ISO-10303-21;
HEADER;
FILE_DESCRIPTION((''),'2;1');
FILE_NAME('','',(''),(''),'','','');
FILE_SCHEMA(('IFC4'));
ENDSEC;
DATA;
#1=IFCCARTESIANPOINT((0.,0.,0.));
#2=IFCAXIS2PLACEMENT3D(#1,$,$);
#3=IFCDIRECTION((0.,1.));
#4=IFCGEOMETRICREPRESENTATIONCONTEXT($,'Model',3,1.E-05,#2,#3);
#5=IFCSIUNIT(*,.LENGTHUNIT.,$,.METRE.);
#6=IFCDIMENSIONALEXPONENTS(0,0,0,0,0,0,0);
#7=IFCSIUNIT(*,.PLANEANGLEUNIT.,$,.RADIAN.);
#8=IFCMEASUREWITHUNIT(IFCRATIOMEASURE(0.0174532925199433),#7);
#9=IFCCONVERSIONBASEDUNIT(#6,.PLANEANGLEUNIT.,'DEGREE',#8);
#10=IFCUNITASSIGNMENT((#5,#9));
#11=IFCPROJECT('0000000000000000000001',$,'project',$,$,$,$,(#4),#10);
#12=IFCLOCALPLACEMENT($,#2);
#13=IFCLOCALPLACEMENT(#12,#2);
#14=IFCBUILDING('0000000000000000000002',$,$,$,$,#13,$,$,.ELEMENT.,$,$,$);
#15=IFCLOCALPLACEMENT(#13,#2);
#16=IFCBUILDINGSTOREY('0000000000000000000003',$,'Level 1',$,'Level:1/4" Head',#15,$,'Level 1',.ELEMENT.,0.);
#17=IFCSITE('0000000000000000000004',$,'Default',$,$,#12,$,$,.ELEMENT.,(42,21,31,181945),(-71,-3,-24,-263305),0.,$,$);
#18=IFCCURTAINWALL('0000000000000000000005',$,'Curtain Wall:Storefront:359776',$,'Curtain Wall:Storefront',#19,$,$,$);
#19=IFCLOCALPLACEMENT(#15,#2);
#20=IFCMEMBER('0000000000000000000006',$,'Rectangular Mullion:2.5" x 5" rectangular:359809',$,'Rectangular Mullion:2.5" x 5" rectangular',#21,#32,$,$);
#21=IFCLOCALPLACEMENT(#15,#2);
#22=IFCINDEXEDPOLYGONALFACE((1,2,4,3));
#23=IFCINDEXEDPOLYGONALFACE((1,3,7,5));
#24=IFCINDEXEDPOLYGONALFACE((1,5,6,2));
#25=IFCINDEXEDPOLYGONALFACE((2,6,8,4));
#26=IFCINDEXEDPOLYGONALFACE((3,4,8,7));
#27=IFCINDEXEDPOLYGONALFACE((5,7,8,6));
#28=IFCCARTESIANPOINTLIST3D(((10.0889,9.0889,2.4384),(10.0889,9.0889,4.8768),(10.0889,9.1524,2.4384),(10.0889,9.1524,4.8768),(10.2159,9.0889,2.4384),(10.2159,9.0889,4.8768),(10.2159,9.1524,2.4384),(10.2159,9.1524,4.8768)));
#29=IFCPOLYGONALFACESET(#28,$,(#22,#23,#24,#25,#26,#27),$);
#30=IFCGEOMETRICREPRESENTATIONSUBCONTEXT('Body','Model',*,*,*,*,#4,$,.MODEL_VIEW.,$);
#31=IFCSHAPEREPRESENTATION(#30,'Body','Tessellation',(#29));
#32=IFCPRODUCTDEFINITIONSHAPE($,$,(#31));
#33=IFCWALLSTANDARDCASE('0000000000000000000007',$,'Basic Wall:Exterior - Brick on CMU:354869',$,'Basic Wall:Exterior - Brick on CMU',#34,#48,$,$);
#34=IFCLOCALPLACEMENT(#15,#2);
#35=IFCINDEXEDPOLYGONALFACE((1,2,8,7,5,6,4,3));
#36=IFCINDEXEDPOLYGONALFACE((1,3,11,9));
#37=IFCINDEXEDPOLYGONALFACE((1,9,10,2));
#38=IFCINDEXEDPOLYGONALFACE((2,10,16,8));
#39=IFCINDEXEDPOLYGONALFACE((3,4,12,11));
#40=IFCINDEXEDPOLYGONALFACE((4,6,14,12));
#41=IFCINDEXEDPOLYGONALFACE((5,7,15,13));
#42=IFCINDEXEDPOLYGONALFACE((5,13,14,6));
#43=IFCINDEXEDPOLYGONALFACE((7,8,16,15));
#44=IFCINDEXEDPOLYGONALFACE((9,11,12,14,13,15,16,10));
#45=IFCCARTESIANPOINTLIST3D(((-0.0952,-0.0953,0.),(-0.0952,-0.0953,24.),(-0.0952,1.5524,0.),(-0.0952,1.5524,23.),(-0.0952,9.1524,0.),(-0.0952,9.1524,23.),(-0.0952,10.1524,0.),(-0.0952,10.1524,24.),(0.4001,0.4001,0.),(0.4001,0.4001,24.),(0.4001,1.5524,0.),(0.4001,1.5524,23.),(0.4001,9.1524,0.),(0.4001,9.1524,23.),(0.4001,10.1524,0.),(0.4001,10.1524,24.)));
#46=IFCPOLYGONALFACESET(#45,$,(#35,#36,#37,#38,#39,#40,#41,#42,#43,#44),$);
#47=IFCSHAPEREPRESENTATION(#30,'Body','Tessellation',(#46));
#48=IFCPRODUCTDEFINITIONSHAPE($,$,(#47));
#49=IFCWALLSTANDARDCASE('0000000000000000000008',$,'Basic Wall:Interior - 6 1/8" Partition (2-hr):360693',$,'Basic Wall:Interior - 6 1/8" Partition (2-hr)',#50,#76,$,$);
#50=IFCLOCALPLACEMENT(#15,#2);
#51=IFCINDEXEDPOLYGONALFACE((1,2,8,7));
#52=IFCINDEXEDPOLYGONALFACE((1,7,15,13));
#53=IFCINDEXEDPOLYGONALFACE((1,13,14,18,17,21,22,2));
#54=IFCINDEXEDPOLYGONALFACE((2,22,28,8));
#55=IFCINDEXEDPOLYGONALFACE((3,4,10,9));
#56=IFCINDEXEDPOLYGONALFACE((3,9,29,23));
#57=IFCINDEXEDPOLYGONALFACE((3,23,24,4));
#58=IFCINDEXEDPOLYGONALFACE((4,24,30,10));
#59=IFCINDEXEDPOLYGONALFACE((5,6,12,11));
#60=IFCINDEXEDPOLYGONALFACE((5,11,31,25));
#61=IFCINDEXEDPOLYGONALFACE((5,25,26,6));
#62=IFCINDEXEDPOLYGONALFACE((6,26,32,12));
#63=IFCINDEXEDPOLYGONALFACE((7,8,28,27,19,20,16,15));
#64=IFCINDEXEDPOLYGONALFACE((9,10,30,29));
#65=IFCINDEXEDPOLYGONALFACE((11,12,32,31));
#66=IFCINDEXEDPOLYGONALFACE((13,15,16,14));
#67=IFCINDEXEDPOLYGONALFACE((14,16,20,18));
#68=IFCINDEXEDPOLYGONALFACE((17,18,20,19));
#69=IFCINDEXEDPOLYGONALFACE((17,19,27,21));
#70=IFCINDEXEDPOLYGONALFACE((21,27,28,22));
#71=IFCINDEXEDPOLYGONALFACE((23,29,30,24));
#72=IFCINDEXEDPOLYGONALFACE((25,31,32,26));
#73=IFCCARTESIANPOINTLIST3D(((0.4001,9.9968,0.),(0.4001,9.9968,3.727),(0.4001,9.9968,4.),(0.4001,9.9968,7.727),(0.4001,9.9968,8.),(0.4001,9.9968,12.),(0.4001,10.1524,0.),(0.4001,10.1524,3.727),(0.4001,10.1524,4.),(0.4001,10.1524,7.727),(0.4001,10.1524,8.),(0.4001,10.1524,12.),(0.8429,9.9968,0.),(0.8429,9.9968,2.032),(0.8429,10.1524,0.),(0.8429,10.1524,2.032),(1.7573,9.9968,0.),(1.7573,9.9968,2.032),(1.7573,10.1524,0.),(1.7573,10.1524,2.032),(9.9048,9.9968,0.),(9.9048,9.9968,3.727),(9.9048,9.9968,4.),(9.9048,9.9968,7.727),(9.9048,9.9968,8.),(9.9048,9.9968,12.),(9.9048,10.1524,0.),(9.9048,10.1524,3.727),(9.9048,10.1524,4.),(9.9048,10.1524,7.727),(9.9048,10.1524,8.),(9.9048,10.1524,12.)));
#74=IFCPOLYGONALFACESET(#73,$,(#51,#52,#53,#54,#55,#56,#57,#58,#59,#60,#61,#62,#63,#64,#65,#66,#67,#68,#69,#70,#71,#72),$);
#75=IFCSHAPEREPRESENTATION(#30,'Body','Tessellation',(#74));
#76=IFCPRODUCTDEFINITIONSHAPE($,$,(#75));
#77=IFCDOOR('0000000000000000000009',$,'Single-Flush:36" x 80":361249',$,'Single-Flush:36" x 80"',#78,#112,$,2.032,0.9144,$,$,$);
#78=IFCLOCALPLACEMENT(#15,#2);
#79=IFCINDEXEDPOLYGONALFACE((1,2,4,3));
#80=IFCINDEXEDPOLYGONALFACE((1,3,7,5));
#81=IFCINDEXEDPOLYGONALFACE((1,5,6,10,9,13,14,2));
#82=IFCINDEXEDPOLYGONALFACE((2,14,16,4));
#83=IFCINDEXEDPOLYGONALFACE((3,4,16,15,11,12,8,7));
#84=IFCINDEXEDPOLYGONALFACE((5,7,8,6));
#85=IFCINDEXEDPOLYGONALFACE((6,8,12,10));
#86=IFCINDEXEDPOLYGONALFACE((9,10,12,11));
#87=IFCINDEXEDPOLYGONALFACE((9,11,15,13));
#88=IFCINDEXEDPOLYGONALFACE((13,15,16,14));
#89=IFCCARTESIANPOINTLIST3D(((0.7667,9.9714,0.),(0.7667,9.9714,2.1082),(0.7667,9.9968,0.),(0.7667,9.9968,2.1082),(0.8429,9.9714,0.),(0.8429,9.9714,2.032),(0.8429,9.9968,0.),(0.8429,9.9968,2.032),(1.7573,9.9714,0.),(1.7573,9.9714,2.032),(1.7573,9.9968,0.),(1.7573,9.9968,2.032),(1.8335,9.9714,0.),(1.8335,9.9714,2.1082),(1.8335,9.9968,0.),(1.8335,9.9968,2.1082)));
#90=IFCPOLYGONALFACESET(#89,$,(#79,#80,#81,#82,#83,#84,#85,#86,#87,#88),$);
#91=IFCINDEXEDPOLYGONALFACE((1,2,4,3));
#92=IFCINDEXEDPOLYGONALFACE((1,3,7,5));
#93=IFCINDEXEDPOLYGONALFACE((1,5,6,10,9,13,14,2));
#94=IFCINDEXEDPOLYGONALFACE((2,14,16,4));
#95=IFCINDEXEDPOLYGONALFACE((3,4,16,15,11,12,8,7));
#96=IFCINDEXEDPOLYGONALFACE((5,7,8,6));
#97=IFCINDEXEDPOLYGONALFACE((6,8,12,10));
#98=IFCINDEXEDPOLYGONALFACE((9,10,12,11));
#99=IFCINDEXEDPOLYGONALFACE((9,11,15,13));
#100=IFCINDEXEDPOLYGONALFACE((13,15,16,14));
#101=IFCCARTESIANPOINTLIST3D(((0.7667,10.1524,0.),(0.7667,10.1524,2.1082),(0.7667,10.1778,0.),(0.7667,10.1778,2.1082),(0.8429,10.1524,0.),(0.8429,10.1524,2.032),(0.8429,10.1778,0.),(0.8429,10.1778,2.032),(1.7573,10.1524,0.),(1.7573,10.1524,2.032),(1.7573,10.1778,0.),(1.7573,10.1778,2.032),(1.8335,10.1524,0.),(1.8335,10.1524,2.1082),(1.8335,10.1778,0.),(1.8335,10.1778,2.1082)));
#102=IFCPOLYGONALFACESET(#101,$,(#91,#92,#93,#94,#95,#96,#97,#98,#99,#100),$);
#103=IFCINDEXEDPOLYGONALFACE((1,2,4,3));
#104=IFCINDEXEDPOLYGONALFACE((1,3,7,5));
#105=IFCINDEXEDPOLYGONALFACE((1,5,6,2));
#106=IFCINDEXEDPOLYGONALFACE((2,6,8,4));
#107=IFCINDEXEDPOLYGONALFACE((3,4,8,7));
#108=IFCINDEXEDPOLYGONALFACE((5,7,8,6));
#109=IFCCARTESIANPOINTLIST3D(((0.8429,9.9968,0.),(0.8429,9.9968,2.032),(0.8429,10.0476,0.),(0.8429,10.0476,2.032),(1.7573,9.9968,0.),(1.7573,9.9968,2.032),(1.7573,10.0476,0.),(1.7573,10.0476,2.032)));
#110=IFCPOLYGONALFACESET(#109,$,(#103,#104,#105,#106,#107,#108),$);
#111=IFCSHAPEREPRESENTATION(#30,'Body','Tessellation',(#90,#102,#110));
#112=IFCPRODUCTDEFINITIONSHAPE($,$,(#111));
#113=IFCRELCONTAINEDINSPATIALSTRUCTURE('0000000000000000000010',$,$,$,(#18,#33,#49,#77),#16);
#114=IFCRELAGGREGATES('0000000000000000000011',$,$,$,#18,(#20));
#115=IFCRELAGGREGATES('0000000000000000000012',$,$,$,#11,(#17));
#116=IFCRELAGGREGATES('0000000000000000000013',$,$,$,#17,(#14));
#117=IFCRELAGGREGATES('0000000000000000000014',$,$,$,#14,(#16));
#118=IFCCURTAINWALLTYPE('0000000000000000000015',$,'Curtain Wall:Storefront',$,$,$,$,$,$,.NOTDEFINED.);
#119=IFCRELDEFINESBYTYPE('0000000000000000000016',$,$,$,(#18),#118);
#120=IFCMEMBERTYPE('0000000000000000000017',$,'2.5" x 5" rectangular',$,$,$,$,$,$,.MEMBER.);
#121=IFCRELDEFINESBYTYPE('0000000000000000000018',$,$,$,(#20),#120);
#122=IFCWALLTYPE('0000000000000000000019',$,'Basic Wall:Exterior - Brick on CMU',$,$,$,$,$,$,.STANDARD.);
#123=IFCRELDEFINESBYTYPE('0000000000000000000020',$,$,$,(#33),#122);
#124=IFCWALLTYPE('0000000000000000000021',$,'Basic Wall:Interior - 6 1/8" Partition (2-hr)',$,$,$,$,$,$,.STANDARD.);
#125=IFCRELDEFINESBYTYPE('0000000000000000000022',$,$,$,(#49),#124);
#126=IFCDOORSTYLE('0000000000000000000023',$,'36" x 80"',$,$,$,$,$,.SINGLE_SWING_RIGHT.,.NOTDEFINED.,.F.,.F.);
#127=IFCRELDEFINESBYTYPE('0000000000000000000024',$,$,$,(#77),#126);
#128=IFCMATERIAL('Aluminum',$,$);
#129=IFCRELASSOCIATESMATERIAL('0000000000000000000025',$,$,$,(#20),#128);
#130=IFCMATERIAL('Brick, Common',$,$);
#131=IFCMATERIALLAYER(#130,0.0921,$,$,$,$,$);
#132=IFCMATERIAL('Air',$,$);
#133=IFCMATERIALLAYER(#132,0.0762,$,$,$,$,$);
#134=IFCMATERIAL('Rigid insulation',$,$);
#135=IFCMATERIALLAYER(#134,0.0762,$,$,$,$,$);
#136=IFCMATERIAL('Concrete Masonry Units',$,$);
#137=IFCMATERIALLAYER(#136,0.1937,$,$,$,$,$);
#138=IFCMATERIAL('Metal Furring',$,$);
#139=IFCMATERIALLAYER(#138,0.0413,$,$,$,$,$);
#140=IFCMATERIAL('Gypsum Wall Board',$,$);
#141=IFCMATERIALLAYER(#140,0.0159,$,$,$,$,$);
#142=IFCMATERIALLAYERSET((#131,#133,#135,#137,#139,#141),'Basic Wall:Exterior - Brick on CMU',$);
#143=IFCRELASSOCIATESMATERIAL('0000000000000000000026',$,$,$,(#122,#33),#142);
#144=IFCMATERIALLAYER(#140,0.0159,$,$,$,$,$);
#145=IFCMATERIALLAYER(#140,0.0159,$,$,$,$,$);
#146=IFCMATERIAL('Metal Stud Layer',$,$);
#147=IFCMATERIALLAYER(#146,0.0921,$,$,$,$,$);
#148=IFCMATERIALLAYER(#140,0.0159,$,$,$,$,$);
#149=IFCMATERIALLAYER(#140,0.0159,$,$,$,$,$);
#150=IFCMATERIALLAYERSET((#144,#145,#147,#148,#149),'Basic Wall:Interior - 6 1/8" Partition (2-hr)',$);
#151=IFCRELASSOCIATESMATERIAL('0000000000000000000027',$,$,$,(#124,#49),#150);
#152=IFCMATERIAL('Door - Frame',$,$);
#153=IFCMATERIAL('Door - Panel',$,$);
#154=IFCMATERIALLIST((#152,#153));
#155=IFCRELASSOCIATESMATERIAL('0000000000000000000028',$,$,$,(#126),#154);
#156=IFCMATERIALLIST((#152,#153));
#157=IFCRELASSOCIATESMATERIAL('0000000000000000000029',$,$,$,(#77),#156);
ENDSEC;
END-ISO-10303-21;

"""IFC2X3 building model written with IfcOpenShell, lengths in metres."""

from ifc_helpers import new_model, entity, si_unit, converted_unit, direction, frame, frame_2d, origin, origin_2d_with_axis, place, context, subcontext, project, spatial, polyline, rectangle, outline, extrude, source, transform, mapped, material, material_list, layer, layer_set, layer_usage, type_object, type_shapes, element, fill, aggregate, save


model = new_model("IFC2X3")

# Units and contexts
model_context = context("Model", 3, precision=1e-05, world=origin(), true_north=direction((0.0, 1.0)))
body_context = subcontext(model_context, "Body", "Model", "MODEL_VIEW")
ifc_project = project(units=[si_unit("LENGTHUNIT", "METRE"), converted_unit("PLANEANGLEUNIT", "DEGREE", entity("IfcRatioMeasure", 0.0174532925199433), si_unit("PLANEANGLEUNIT", "RADIAN"), dimensions=[0, 0, 0, 0, 0, 0, 0])], contexts=[model_context])

# Site, building, storey
site_placement = place(None, origin())
site = spatial("IfcSite", under=ifc_project, at=site_placement, Name="Default", CompositionType="ELEMENT", RefLatitude=(42, 21, 31, 181945), RefLongitude=(-71, -3, -24, -263305), RefElevation=0.0)
building_placement = place(site_placement, origin())
building = spatial("IfcBuilding", under=site, at=building_placement, CompositionType="ELEMENT")
storey_placement = place(building_placement, origin())
storey = spatial("IfcBuildingStorey", under=building, at=storey_placement, Name="Level 1", ObjectType="Level:1/4\" Head", LongName="Level 1", CompositionType="ELEMENT", Elevation=0.0)

# Curtain wall, member
curtain_wall_type = type_object("IfcCurtainWallType", Name="Curtain Wall:Storefront", PredefinedType="NOTDEFINED")
curtain_wall_placement = place(storey_placement, origin())
curtain_wall = element("IfcCurtainWall", 1, at=curtain_wall_placement, inside=storey, type_object=curtain_wall_type, Name="Curtain Wall:Storefront:359776", ObjectType="Curtain Wall:Storefront")
ifc_material_1 = material(Name="Aluminum")
member_type = type_object("IfcMemberType", Name="2.5\" x 5\" rectangular", PredefinedType="MEMBER")
shared_shape_1 = source(origin(), body_context, "Body", "SweptSolid", [
    extrude(rectangle(XDim=0.127, YDim=0.0635, at=origin_2d_with_axis()), frame((-0.0318, 0.0, -2.4384), z_axis=(0.0, 0.0, 1.0), x_axis=(0.0, -1.0, 0.0)), (0.0, 0.0, 1.0), 2.4384),
])
type_shapes(member_type, [shared_shape_1])
member_placement = place(storey_placement, frame((10.1524, 9.1524, 2.4384), z_axis=(0.0, 0.0, -1.0), x_axis=(0.0, 1.0, 0.0)))
member = element("IfcMember", 2, at=member_placement, type_object=member_type, material=ifc_material_1, Name="Rectangular Mullion:2.5\" x 5\" rectangular:359809", ObjectType="Rectangular Mullion:2.5\" x 5\" rectangular", context=body_context, shape_type="MappedRepresentation", body=[
    mapped(shared_shape_1, transform((0.0, 0.0, 0.0), scale=1.0)),
])
aggregate(curtain_wall, [member])

# Wall, opening
ifc_material_2 = material(Name="Brick, Common")
ifc_layer_1 = layer(ifc_material_2, 0.0921)
ifc_material_3 = material(Name="Air")
ifc_layer_2 = layer(ifc_material_3, 0.0762)
ifc_material_4 = material(Name="Rigid insulation")
ifc_layer_3 = layer(ifc_material_4, 0.0762)
ifc_material_5 = material(Name="Concrete Masonry Units")
ifc_layer_4 = layer(ifc_material_5, 0.1937)
ifc_material_6 = material(Name="Metal Furring")
ifc_layer_5 = layer(ifc_material_6, 0.0413)
ifc_material_7 = material(Name="Gypsum Wall Board")
ifc_layer_6 = layer(ifc_material_7, 0.0159)
ifc_layer_set_1 = layer_set([ifc_layer_1, ifc_layer_2, ifc_layer_3, ifc_layer_4, ifc_layer_5, ifc_layer_6], Name="Basic Wall:Exterior - Brick on CMU")
ifc_layer_usage_1 = layer_usage(ifc_layer_set_1, "AXIS2", "POSITIVE", -0.2477)
wall_type_1 = type_object("IfcWallType", Name="Basic Wall:Exterior - Brick on CMU", PredefinedType="STANDARD", material=ifc_layer_set_1)
wall_1_placement = place(storey_placement, frame((0.1524, 10.1524, 0.0), z_axis=(0.0, 0.0, 1.0), x_axis=(0.0, -1.0, 0.0)))
wall_1 = element("IfcWallStandardCase", 3, at=wall_1_placement, inside=storey, type_object=wall_type_1, material=ifc_layer_usage_1, Name="Basic Wall:Exterior - Brick on CMU:354869", ObjectType="Basic Wall:Exterior - Brick on CMU", context=body_context, shape_type="SweptSolid", body=[
    extrude(outline(polyline([(0.0, -0.2477), (10.2477, -0.2477), (9.7523, 0.2477), (0.4175, 0.2477), (0.0, 0.2477), (0.0, -0.2477)])), origin(), (0.0, 0.0, 1.0), 24.0),
])
opening_1_placement = place(wall_1_placement, frame((8.6, -0.4001, 0.0)))
element("IfcOpeningElement", 4, at=opening_1_placement, cuts=wall_1, ObjectType="Opening", context=body_context, shape_type="SweptSolid", body=[
    extrude(rectangle(XDim=23.0, YDim=7.6, at=frame_2d((0.0, 0.0), x_axis=(0.0, 1.0))), frame((-3.8, 0.0, 11.5), z_axis=(0.0, 1.0, 0.0), x_axis=(-1.0, 0.0, 0.0)), (0.0, 0.0, 1.0), 0.8001),
])

# Wall, openings, door
ifc_layer_7 = layer(ifc_material_7, 0.0159)
ifc_layer_8 = layer(ifc_material_7, 0.0159)
ifc_material_8 = material(Name="Metal Stud Layer")
ifc_layer_9 = layer(ifc_material_8, 0.0921)
ifc_layer_10 = layer(ifc_material_7, 0.0159)
ifc_layer_11 = layer(ifc_material_7, 0.0159)
ifc_layer_set_2 = layer_set([ifc_layer_7, ifc_layer_8, ifc_layer_9, ifc_layer_10, ifc_layer_11], Name="Basic Wall:Interior - 6 1/8\" Partition (2-hr)")
ifc_layer_usage_2 = layer_usage(ifc_layer_set_2, "AXIS2", "POSITIVE", -0.0778)
wall_type_2 = type_object("IfcWallType", Name="Basic Wall:Interior - 6 1/8\" Partition (2-hr)", PredefinedType="STANDARD", material=ifc_layer_set_2)
wall_2_placement = place(storey_placement, frame((9.9048, 10.0746, 0.0), z_axis=(0.0, 0.0, 1.0), x_axis=(-1.0, 0.0, 0.0)))
wall_2 = element("IfcWallStandardCase", 5, at=wall_2_placement, inside=storey, type_object=wall_type_2, material=ifc_layer_usage_2, Name="Basic Wall:Interior - 6 1/8\" Partition (2-hr):360693", ObjectType="Basic Wall:Interior - 6 1/8\" Partition (2-hr)", context=body_context, shape_type="SweptSolid", body=[
    extrude(rectangle(XDim=9.5047, YDim=0.1556, at=frame_2d((4.7523, 0.0), x_axis=(-1.0, 0.0))), origin(), (0.0, 0.0, 1.0), 12.0),
])
opening_2_placement = place(storey_placement, frame((9.9048, 10.0746, 0.0), z_axis=(0.0, 0.0, 1.0), x_axis=(-1.0, 0.0, 0.0)))
element("IfcOpeningElement", 6, at=opening_2_placement, cuts=wall_2, ObjectType="Opening", context=body_context, shape_type="SweptSolid", body=[
    extrude(rectangle(XDim=9.5047, YDim=0.1556, at=origin_2d_with_axis()), frame((4.7523, 0.0, 7.727)), (0.0, 0.0, 1.0), 0.2731),
])
opening_3_placement = place(storey_placement, frame((9.9048, 10.0746, 0.0), z_axis=(0.0, 0.0, 1.0), x_axis=(-1.0, 0.0, 0.0)))
element("IfcOpeningElement", 7, at=opening_3_placement, cuts=wall_2, ObjectType="Opening", context=body_context, shape_type="SweptSolid", body=[
    extrude(rectangle(XDim=9.5047, YDim=0.1556, at=origin_2d_with_axis()), frame((4.7523, 0.0, 3.727)), (0.0, 0.0, 1.0), 0.2731),
])
opening_4_placement = place(wall_2_placement, frame((8.1475, -0.0778, 0.0)))
opening_4 = element("IfcOpeningElement", 8, at=opening_4_placement, cuts=wall_2, ObjectType="Opening", context=body_context, shape_type="SweptSolid", body=[
    extrude(rectangle(XDim=0.9144, YDim=2.032, at=frame_2d((1.016, 0.4572), x_axis=(0.0, 1.0))), frame((0.0, 0.0, 0.0), z_axis=(0.0, 1.0, 0.0), x_axis=(0.0, 0.0, 1.0)), (0.0, 0.0, 1.0), 0.1556),
])
ifc_material_9 = material(Name="Door - Frame")
ifc_material_10 = material(Name="Door - Panel")
ifc_material_list_1 = material_list([ifc_material_9, ifc_material_10])
ifc_material_list_2 = material_list([ifc_material_9, ifc_material_10])
door_style = type_object("IfcDoorStyle", Name="36\" x 80\"", ConstructionType="NOTDEFINED", OperationType="SINGLE_SWING_RIGHT", ParameterTakesPrecedence=False, Sizeable=False, material=ifc_material_list_2)
shared_shape_2 = source(origin(), body_context, "Body", "SweptSolid", [
    extrude(outline(polyline([(-0.5334, -1.0732), (0.5334, -1.0732), (0.5334, 1.0351), (0.4572, 1.0351), (0.4572, -0.997), (-0.4572, -0.997), (-0.4572, 1.0351), (-0.5334, 1.0351), (-0.5334, -1.0732)])), frame((0.4572, 0.1556, 1.0351), z_axis=(0.0, 1.0, 0.0), x_axis=(1.0, 0.0, 0.0)), (0.0, 0.0, 1.0), 0.0254),
    extrude(outline(polyline([(-1.0732, -0.5334), (1.0351, -0.5334), (1.0351, -0.4572), (-0.997, -0.4572), (-0.997, 0.4572), (1.0351, 0.4572), (1.0351, 0.5334), (-1.0732, 0.5334), (-1.0732, -0.5334)])), frame((0.4572, -0.0254, 1.0351), z_axis=(0.0, 1.0, 0.0), x_axis=(0.0, 0.0, -1.0)), (0.0, 0.0, 1.0), 0.0254),
    extrude(rectangle(XDim=0.0508, YDim=0.9144, at=frame_2d((0.0, 0.0), x_axis=(1.0, 0.0))), frame((0.4572, 0.1302, 0.0), z_axis=(0.0, 0.0, 1.0), x_axis=(0.0, 1.0, 0.0)), (0.0, 0.0, 1.0), 2.032),
])
type_shapes(door_style, [shared_shape_2])
door_placement = place(opening_4_placement, origin())
door = element("IfcDoor", 9, at=door_placement, inside=storey, type_object=door_style, material=ifc_material_list_1, Name="Single-Flush:36\" x 80\":361249", ObjectType="Single-Flush:36\" x 80\"", OverallHeight=2.032, OverallWidth=0.9144, context=body_context, shape_type="MappedRepresentation", body=[
    mapped(shared_shape_2, transform((0.0, 0.0, 0.0), scale=1.0)),
])
fill(opening_4, door)

save(model, "model.ifc")
